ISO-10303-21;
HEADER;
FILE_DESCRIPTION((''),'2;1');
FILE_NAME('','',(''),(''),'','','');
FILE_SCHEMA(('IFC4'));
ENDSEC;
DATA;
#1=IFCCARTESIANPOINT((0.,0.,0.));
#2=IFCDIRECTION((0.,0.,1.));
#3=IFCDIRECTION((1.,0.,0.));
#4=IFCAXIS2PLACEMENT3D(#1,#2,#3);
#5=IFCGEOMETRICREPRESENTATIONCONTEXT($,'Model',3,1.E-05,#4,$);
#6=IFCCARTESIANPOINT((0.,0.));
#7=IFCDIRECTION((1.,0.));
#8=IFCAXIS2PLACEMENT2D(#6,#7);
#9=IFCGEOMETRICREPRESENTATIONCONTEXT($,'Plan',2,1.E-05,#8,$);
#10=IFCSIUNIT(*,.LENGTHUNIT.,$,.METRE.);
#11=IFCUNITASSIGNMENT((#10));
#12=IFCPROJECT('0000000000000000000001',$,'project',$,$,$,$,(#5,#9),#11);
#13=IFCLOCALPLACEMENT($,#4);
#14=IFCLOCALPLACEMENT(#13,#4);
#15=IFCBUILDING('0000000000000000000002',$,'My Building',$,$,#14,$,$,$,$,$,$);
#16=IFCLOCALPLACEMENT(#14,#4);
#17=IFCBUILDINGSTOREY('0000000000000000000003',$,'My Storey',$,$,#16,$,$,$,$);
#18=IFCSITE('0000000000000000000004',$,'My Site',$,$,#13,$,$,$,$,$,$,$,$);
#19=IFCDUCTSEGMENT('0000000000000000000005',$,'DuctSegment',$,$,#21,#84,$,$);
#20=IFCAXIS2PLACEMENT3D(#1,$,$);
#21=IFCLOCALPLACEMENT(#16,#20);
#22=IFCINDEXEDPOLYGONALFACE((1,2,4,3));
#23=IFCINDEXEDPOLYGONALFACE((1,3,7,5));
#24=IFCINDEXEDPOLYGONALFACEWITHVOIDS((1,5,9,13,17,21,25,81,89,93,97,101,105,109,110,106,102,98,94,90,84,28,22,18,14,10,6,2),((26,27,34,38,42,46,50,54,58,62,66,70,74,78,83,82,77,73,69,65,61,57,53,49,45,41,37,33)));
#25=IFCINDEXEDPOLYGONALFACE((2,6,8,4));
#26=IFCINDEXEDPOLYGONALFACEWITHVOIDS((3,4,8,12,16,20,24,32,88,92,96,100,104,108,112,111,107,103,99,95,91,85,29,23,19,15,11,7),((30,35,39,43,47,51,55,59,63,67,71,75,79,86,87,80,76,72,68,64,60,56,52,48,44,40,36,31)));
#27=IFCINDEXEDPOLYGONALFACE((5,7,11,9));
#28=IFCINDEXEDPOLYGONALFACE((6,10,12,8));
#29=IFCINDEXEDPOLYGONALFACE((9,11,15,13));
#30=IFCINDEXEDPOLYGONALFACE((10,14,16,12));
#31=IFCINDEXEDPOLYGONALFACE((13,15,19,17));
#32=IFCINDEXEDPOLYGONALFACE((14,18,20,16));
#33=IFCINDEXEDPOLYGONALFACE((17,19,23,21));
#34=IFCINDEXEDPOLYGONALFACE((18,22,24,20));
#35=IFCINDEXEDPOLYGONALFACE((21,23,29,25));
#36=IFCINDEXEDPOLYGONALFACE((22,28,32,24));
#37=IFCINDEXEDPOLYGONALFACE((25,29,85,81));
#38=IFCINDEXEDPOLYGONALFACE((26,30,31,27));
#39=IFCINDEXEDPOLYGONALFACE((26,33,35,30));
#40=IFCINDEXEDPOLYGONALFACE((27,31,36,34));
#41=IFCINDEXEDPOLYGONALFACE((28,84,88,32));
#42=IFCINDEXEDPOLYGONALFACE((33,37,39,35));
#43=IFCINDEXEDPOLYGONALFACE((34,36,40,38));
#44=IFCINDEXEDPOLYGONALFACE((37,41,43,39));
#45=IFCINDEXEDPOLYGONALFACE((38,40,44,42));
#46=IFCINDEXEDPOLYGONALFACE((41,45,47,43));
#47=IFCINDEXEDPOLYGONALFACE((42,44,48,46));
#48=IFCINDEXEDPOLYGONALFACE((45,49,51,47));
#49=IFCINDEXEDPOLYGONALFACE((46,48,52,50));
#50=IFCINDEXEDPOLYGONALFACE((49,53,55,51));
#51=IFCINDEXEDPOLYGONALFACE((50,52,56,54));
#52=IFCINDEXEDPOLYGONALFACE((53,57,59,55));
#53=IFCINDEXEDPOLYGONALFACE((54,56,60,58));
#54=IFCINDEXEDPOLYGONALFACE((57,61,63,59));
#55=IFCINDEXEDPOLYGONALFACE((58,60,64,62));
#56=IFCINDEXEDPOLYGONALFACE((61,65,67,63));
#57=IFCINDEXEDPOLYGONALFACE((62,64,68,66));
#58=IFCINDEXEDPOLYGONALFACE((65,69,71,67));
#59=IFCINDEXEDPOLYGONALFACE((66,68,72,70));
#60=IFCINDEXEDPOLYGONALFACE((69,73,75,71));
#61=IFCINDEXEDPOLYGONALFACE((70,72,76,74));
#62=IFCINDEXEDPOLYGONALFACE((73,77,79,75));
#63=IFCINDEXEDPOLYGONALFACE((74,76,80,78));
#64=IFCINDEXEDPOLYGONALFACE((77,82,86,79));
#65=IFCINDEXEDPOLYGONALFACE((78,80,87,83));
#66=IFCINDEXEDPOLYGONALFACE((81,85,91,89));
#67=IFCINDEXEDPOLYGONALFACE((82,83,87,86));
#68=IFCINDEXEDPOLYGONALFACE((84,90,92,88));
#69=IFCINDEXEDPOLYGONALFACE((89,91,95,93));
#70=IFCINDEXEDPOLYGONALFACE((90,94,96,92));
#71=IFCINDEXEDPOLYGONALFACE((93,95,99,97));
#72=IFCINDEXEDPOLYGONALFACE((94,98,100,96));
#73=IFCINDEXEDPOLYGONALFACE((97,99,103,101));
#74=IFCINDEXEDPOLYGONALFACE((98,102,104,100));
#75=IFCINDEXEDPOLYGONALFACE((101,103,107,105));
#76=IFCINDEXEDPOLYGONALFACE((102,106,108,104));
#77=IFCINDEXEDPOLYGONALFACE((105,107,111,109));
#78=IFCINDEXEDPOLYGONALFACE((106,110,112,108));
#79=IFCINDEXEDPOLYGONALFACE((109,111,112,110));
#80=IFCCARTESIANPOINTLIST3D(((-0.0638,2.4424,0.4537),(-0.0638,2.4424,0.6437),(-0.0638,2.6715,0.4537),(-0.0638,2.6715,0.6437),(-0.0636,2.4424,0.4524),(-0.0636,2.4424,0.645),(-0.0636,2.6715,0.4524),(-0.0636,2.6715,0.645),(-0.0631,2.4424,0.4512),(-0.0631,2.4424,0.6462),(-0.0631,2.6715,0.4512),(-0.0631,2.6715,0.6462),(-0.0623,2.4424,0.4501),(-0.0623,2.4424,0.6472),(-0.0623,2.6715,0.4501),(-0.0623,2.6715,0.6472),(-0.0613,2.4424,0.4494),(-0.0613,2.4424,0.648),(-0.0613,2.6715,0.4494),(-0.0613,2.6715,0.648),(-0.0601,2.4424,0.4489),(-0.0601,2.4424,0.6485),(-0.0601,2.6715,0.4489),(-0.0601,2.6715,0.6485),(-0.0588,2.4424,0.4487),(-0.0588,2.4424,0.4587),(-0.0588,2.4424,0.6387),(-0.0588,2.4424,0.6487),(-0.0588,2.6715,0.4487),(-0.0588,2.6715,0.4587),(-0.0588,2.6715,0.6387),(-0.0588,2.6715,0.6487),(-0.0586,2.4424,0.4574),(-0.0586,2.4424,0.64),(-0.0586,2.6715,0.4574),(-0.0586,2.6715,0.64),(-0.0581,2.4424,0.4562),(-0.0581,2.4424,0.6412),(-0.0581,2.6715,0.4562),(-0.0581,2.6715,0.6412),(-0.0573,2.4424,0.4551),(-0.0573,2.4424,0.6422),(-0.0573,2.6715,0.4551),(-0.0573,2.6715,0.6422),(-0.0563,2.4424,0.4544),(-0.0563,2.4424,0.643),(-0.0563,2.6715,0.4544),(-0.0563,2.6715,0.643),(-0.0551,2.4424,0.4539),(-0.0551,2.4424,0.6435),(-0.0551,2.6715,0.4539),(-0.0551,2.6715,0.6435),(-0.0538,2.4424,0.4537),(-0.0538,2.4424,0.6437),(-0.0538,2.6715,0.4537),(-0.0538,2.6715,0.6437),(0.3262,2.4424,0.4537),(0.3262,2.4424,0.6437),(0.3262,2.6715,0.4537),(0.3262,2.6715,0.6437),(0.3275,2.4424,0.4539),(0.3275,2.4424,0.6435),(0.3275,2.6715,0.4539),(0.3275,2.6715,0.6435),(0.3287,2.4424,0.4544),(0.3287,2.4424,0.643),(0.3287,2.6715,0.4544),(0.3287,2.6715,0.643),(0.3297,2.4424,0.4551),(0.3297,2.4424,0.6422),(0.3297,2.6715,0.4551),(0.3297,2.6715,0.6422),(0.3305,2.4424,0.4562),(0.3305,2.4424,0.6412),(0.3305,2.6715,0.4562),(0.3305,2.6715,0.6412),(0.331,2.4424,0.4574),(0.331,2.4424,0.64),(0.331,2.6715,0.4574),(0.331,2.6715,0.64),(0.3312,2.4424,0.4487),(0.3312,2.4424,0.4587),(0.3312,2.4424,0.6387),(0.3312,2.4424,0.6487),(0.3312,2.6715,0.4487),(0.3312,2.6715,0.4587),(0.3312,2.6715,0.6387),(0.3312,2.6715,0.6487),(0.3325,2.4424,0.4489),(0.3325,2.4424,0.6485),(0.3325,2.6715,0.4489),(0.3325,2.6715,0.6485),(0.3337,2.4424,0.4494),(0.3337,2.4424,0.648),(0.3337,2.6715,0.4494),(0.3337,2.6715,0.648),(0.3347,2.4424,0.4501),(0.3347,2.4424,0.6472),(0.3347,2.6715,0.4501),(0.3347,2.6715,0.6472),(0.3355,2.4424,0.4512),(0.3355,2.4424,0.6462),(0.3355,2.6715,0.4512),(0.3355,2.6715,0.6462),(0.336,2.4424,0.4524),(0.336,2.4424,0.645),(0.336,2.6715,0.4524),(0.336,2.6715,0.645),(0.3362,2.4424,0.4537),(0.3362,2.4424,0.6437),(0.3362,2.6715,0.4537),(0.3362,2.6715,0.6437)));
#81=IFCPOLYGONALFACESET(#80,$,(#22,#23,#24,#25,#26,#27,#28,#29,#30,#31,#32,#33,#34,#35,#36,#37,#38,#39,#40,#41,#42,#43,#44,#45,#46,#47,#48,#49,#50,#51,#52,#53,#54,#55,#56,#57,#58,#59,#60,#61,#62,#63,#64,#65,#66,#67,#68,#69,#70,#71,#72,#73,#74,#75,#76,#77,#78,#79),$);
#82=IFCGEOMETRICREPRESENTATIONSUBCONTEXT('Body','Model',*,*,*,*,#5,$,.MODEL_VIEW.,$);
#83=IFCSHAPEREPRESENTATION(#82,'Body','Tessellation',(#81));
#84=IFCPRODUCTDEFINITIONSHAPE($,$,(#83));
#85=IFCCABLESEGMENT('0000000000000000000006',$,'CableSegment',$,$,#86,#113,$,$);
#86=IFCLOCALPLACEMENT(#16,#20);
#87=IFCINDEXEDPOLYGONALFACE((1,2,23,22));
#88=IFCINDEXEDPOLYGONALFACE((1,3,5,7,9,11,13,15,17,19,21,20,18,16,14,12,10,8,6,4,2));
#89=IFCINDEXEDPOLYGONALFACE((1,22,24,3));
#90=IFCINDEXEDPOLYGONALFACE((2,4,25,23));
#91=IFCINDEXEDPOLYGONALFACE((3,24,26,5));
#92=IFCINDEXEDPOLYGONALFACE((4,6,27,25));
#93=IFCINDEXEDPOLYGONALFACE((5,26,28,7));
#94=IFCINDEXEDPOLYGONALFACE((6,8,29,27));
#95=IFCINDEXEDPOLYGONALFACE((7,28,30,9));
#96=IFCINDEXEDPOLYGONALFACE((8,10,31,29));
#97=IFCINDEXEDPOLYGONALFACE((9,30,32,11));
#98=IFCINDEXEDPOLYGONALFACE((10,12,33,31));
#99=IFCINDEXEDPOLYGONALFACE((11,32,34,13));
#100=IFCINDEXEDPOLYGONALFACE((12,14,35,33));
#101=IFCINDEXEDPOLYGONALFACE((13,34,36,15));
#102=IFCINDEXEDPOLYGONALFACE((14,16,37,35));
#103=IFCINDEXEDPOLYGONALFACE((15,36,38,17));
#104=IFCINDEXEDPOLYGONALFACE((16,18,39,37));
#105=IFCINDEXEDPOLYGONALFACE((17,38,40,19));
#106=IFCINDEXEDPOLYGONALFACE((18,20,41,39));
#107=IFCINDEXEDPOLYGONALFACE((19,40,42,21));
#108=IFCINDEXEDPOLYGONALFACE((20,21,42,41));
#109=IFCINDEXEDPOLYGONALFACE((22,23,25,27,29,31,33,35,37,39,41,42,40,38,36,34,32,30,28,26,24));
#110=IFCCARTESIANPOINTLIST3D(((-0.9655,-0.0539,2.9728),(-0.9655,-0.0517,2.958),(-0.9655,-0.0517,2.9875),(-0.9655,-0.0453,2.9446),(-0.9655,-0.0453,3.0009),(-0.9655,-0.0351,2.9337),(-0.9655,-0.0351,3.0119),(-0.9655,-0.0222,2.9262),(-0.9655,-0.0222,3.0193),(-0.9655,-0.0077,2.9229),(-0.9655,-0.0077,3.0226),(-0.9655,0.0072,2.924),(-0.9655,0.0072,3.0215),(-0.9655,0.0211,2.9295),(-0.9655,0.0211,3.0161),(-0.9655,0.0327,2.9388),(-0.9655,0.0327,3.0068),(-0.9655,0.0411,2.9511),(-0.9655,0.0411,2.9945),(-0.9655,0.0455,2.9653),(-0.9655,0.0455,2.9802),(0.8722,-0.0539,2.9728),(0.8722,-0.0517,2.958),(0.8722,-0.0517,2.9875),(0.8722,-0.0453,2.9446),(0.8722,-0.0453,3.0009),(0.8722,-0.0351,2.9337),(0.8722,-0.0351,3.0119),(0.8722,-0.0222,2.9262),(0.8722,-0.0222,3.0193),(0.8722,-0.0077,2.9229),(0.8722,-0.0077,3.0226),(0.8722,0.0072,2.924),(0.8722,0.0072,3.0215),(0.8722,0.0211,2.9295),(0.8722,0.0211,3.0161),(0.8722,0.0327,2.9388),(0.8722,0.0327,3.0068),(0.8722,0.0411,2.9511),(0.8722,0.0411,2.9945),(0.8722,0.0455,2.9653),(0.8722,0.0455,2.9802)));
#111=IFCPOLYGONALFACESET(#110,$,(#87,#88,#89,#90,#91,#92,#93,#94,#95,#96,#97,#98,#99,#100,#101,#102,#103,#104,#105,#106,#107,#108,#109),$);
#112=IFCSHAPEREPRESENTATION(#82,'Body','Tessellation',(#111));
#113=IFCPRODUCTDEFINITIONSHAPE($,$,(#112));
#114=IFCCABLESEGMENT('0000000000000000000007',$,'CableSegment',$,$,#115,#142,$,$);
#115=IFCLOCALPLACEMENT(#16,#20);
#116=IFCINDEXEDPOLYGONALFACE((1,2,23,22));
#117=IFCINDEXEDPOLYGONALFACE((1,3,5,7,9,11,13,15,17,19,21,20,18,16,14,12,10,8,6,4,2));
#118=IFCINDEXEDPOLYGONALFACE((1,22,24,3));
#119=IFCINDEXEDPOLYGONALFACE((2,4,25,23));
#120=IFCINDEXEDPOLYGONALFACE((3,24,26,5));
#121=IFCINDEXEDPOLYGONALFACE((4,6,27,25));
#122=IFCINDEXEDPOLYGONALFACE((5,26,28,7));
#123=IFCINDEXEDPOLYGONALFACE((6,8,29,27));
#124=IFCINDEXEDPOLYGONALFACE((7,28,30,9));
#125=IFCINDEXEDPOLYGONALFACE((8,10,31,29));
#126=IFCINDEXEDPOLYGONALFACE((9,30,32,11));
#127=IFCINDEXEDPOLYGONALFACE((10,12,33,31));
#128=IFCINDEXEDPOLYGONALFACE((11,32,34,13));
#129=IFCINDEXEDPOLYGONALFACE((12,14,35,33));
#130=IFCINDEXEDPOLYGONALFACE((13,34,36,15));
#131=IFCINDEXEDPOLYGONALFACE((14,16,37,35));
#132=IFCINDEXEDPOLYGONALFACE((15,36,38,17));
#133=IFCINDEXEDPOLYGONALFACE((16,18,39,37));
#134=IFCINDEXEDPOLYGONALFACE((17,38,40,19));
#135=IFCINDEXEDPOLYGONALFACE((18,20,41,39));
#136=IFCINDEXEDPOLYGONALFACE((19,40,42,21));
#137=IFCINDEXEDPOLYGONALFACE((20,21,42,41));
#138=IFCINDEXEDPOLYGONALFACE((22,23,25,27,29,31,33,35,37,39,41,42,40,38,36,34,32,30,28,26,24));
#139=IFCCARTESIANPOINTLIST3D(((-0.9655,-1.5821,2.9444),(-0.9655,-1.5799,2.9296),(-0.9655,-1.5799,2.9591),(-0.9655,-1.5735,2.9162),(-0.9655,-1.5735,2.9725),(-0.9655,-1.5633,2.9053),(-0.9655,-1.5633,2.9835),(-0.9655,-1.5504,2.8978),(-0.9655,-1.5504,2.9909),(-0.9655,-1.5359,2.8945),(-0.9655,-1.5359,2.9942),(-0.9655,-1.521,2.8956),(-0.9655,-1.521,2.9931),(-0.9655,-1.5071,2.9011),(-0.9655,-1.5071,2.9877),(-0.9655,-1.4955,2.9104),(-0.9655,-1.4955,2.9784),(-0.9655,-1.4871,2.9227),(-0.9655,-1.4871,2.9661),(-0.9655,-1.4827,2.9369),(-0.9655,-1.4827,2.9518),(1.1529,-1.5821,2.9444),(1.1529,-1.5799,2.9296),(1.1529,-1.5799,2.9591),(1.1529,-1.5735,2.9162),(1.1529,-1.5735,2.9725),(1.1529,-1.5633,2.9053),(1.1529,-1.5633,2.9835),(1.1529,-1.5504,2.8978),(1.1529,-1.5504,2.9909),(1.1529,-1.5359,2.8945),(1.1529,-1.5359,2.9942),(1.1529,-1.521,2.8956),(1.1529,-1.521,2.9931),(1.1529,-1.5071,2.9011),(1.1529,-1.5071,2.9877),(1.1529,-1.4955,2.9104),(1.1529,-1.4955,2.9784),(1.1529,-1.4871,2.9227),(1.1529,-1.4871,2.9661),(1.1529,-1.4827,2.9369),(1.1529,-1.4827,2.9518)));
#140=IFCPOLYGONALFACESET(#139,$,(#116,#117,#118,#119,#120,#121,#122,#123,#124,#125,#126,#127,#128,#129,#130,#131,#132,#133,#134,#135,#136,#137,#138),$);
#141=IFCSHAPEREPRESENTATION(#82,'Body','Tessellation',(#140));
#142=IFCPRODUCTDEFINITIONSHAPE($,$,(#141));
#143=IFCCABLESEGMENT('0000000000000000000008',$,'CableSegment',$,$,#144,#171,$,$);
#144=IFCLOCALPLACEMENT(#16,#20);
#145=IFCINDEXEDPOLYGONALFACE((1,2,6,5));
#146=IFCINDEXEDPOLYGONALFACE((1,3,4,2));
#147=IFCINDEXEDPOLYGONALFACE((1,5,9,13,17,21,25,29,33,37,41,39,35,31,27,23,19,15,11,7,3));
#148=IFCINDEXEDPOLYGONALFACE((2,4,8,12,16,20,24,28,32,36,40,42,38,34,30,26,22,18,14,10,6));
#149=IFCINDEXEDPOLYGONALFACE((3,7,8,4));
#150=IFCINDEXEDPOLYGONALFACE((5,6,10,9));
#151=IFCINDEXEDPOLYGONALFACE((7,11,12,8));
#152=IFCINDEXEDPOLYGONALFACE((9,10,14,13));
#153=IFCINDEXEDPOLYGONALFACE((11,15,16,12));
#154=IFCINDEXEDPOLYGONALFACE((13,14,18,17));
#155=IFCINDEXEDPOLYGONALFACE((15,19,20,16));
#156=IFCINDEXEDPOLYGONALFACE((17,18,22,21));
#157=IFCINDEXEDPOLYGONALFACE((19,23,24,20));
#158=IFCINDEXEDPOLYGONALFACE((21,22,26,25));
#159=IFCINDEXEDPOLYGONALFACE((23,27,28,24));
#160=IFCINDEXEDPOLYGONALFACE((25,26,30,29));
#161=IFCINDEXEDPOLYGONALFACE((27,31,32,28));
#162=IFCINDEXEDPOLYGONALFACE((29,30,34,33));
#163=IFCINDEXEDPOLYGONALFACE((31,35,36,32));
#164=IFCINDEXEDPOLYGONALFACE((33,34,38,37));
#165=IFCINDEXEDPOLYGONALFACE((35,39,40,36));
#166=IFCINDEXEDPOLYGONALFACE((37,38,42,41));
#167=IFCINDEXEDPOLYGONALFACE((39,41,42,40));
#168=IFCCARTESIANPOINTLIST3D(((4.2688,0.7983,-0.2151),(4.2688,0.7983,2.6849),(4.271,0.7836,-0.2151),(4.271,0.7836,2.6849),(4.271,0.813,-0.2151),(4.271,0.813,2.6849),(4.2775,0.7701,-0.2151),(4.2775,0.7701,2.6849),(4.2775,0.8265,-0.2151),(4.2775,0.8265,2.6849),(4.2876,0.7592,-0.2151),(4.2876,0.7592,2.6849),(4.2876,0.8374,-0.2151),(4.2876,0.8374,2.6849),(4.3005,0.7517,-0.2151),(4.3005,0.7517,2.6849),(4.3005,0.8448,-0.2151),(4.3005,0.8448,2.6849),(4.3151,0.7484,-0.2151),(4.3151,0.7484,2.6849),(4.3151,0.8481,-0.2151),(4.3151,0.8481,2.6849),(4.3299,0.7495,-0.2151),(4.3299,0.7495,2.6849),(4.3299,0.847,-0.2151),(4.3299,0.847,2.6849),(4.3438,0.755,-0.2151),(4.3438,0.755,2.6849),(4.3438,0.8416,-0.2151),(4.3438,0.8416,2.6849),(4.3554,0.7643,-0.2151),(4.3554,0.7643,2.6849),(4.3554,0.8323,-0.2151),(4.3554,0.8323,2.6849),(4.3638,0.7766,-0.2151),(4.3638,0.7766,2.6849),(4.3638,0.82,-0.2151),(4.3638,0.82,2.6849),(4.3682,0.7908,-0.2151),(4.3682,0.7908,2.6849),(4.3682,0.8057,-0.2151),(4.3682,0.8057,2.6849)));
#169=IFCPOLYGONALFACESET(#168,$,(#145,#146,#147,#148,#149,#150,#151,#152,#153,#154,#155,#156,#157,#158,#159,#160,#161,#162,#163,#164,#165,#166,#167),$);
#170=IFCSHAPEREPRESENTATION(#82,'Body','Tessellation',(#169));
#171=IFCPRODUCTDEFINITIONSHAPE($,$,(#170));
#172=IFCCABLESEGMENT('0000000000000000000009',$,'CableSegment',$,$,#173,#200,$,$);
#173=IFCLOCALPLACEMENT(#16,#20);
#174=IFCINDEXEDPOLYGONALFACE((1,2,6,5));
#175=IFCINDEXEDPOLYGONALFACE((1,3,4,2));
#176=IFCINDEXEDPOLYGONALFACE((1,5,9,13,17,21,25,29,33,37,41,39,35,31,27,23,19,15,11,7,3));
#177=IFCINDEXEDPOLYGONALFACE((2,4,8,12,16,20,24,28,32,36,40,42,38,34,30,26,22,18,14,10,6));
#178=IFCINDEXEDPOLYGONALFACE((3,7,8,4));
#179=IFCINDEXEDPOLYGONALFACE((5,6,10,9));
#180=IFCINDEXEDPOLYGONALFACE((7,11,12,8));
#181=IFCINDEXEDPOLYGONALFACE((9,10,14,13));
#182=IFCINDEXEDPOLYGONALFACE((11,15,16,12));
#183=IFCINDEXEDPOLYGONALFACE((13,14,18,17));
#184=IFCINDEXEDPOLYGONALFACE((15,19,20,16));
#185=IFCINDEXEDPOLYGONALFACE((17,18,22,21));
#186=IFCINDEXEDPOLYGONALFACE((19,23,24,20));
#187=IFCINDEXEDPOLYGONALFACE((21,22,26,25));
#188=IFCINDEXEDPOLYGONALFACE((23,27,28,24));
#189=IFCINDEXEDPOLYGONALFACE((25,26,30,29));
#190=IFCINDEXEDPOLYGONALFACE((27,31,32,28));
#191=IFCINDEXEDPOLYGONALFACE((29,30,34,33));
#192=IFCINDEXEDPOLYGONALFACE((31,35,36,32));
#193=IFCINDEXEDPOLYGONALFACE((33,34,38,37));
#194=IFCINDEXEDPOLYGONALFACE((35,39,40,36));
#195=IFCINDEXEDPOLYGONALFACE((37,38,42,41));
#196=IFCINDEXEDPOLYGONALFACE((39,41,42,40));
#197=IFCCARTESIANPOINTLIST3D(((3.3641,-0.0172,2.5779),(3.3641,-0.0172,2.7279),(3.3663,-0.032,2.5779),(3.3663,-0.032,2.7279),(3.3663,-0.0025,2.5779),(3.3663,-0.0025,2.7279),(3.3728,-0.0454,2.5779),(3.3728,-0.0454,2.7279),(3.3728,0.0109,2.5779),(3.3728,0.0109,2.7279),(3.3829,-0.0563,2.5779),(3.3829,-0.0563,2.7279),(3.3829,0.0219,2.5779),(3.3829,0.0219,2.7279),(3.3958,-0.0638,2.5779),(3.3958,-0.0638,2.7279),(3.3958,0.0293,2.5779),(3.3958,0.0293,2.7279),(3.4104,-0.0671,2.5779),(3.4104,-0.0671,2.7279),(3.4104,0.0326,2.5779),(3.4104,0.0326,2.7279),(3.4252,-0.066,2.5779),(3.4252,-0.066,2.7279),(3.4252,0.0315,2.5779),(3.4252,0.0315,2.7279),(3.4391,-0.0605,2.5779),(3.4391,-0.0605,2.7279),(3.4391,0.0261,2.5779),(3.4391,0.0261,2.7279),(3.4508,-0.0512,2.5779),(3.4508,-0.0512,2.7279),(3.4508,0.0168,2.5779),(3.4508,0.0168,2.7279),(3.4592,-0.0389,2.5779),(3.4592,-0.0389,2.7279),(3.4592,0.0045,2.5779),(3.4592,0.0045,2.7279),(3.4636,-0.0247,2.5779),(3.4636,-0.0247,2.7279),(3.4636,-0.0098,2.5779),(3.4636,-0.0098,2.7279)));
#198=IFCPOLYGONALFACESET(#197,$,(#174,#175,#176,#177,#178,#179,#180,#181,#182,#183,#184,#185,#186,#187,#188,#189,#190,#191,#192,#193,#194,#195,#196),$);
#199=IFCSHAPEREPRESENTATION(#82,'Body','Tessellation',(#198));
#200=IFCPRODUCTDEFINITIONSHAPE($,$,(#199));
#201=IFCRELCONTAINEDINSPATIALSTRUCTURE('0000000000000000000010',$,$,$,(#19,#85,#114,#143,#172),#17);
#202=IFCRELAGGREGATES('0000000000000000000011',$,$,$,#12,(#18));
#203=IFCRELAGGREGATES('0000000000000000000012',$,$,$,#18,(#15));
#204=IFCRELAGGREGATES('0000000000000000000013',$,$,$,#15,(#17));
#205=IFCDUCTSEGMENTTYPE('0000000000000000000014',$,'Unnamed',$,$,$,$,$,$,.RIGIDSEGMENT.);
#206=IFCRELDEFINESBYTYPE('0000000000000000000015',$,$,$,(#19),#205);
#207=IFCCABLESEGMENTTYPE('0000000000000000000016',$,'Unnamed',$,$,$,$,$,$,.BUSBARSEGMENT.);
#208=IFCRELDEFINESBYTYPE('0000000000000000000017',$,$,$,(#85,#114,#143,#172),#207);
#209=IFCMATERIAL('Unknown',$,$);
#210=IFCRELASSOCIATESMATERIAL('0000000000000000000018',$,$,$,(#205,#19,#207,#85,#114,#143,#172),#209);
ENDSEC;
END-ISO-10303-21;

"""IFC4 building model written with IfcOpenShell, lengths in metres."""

from ifc_helpers import new_model, si_unit, frame, origin_with_axes, origin_2d_with_axis, place, context, subcontext, project, spatial, hollow_rectangle, circle, extrude, material, material_profile, profile_set, profile_usage, type_object, element, save


model = new_model("IFC4")

# Units and contexts
model_context = context("Model", 3, precision=1e-05, world=origin_with_axes())
plan_context = context("Plan", 2, precision=1e-05, world=origin_2d_with_axis())
body_context_1 = subcontext(model_context, "Body", "Model", "MODEL_VIEW")
ifc_project = project(units=[si_unit("LENGTHUNIT", "METRE")], contexts=[model_context, plan_context])

# Site, building, storey
site_placement = place(None, origin_with_axes())
site = spatial("IfcSite", under=ifc_project, at=site_placement, Name="My Site")
building_placement = place(site_placement, origin_with_axes())
building = spatial("IfcBuilding", under=site, at=building_placement, Name="My Building")
storey_placement = place(building_placement, origin_with_axes())
storey = spatial("IfcBuildingStorey", under=building, at=storey_placement, Name="My Storey")

# Shared definitions
ifc_material = material(Name="Unknown")

# Duct segment
ifc_material_profile_1 = material_profile(ifc_material, hollow_rectangle(XDim=0.4, YDim=0.2, WallThickness=0.005, InnerFilletRadius=0.005, OuterFilletRadius=0.005))
ifc_profile_set_1 = profile_set([ifc_material_profile_1])
duct_segment_type_1 = type_object("IfcDuctSegmentType", Name="Unnamed", PredefinedType="RIGIDSEGMENT", material=ifc_profile_set_1)
ifc_profile_usage_1 = profile_usage(ifc_profile_set_1, cardinal=5)
duct_segment_1_placement = place(storey_placement, frame((0.1362, 2.6715, 0.5487), z_axis=(0.0, -1.0, 0.0), x_axis=(1.0, 0.0, 0.0)))
element("IfcDuctSegment", 1, at=duct_segment_1_placement, inside=storey, type_object=duct_segment_type_1, material=ifc_profile_usage_1, Name="DuctSegment", context=body_context_1, shape_type="SweptSolid", body=[
    extrude(hollow_rectangle(XDim=0.4, YDim=0.2, WallThickness=0.005, InnerFilletRadius=0.005, OuterFilletRadius=0.005), origin_with_axes(), (0.0, 0.0, 1.0), 0.2291),
])

# Cable segments
ifc_material_profile_2 = material_profile(ifc_material, circle(Radius=0.05))
ifc_profile_set_2 = profile_set([ifc_material_profile_2])
ifc_profile_usage_2 = profile_usage(ifc_profile_set_2, cardinal=5)
cable_segment_type = type_object("IfcCableSegmentType", Name="Unnamed", PredefinedType="BUSBARSEGMENT", material=ifc_profile_set_2)
cable_segment_1_placement = place(storey_placement, frame((0.8722, -0.0039, 2.9728), z_axis=(-1.0, 0.0, 0.0), x_axis=(0.0, -1.0, 0.0)))
element("IfcCableSegment", 2, at=cable_segment_1_placement, inside=storey, type_object=cable_segment_type, material=ifc_profile_usage_2, Name="CableSegment", context=body_context_1, shape_type="SweptSolid", body=[
    extrude(circle(Radius=0.05), origin_with_axes(), (0.0, 0.0, 1.0), 1.8377),
])
ifc_profile_usage_3 = profile_usage(ifc_profile_set_2, cardinal=5)
cable_segment_2_placement = place(storey_placement, frame((1.1529, -1.5321, 2.9444), z_axis=(-1.0, 0.0, 0.0), x_axis=(0.0, -1.0, 0.0)))
element("IfcCableSegment", 3, at=cable_segment_2_placement, inside=storey, type_object=cable_segment_type, material=ifc_profile_usage_3, Name="CableSegment", context=body_context_1, shape_type="SweptSolid", body=[
    extrude(circle(Radius=0.05), origin_with_axes(), (0.0, 0.0, 1.0), 2.1184),
])
ifc_profile_usage_4 = profile_usage(ifc_profile_set_2, cardinal=5)
cable_segment_3_placement = place(storey_placement, frame((4.3188, 0.7983, 2.6849), z_axis=(0.0, 0.0, -1.0), x_axis=(-1.0, 0.0, 0.0)))
element("IfcCableSegment", 4, at=cable_segment_3_placement, inside=storey, type_object=cable_segment_type, material=ifc_profile_usage_4, Name="CableSegment", context=body_context_1, shape_type="SweptSolid", body=[
    extrude(circle(Radius=0.05), origin_with_axes(), (0.0, 0.0, 1.0), 2.9),
])
ifc_profile_usage_5 = profile_usage(ifc_profile_set_2, cardinal=5)
cable_segment_4_placement = place(storey_placement, frame((3.4141, -0.0172, 2.7279), z_axis=(0.0, 0.0, -1.0), x_axis=(-1.0, 0.0, 0.0)))
element("IfcCableSegment", 5, at=cable_segment_4_placement, inside=storey, type_object=cable_segment_type, material=ifc_profile_usage_5, Name="CableSegment", context=body_context_1, shape_type="SweptSolid", body=[
    extrude(circle(Radius=0.05), origin_with_axes(), (0.0, 0.0, 1.0), 0.15),
])

save(model, "model.ifc")
